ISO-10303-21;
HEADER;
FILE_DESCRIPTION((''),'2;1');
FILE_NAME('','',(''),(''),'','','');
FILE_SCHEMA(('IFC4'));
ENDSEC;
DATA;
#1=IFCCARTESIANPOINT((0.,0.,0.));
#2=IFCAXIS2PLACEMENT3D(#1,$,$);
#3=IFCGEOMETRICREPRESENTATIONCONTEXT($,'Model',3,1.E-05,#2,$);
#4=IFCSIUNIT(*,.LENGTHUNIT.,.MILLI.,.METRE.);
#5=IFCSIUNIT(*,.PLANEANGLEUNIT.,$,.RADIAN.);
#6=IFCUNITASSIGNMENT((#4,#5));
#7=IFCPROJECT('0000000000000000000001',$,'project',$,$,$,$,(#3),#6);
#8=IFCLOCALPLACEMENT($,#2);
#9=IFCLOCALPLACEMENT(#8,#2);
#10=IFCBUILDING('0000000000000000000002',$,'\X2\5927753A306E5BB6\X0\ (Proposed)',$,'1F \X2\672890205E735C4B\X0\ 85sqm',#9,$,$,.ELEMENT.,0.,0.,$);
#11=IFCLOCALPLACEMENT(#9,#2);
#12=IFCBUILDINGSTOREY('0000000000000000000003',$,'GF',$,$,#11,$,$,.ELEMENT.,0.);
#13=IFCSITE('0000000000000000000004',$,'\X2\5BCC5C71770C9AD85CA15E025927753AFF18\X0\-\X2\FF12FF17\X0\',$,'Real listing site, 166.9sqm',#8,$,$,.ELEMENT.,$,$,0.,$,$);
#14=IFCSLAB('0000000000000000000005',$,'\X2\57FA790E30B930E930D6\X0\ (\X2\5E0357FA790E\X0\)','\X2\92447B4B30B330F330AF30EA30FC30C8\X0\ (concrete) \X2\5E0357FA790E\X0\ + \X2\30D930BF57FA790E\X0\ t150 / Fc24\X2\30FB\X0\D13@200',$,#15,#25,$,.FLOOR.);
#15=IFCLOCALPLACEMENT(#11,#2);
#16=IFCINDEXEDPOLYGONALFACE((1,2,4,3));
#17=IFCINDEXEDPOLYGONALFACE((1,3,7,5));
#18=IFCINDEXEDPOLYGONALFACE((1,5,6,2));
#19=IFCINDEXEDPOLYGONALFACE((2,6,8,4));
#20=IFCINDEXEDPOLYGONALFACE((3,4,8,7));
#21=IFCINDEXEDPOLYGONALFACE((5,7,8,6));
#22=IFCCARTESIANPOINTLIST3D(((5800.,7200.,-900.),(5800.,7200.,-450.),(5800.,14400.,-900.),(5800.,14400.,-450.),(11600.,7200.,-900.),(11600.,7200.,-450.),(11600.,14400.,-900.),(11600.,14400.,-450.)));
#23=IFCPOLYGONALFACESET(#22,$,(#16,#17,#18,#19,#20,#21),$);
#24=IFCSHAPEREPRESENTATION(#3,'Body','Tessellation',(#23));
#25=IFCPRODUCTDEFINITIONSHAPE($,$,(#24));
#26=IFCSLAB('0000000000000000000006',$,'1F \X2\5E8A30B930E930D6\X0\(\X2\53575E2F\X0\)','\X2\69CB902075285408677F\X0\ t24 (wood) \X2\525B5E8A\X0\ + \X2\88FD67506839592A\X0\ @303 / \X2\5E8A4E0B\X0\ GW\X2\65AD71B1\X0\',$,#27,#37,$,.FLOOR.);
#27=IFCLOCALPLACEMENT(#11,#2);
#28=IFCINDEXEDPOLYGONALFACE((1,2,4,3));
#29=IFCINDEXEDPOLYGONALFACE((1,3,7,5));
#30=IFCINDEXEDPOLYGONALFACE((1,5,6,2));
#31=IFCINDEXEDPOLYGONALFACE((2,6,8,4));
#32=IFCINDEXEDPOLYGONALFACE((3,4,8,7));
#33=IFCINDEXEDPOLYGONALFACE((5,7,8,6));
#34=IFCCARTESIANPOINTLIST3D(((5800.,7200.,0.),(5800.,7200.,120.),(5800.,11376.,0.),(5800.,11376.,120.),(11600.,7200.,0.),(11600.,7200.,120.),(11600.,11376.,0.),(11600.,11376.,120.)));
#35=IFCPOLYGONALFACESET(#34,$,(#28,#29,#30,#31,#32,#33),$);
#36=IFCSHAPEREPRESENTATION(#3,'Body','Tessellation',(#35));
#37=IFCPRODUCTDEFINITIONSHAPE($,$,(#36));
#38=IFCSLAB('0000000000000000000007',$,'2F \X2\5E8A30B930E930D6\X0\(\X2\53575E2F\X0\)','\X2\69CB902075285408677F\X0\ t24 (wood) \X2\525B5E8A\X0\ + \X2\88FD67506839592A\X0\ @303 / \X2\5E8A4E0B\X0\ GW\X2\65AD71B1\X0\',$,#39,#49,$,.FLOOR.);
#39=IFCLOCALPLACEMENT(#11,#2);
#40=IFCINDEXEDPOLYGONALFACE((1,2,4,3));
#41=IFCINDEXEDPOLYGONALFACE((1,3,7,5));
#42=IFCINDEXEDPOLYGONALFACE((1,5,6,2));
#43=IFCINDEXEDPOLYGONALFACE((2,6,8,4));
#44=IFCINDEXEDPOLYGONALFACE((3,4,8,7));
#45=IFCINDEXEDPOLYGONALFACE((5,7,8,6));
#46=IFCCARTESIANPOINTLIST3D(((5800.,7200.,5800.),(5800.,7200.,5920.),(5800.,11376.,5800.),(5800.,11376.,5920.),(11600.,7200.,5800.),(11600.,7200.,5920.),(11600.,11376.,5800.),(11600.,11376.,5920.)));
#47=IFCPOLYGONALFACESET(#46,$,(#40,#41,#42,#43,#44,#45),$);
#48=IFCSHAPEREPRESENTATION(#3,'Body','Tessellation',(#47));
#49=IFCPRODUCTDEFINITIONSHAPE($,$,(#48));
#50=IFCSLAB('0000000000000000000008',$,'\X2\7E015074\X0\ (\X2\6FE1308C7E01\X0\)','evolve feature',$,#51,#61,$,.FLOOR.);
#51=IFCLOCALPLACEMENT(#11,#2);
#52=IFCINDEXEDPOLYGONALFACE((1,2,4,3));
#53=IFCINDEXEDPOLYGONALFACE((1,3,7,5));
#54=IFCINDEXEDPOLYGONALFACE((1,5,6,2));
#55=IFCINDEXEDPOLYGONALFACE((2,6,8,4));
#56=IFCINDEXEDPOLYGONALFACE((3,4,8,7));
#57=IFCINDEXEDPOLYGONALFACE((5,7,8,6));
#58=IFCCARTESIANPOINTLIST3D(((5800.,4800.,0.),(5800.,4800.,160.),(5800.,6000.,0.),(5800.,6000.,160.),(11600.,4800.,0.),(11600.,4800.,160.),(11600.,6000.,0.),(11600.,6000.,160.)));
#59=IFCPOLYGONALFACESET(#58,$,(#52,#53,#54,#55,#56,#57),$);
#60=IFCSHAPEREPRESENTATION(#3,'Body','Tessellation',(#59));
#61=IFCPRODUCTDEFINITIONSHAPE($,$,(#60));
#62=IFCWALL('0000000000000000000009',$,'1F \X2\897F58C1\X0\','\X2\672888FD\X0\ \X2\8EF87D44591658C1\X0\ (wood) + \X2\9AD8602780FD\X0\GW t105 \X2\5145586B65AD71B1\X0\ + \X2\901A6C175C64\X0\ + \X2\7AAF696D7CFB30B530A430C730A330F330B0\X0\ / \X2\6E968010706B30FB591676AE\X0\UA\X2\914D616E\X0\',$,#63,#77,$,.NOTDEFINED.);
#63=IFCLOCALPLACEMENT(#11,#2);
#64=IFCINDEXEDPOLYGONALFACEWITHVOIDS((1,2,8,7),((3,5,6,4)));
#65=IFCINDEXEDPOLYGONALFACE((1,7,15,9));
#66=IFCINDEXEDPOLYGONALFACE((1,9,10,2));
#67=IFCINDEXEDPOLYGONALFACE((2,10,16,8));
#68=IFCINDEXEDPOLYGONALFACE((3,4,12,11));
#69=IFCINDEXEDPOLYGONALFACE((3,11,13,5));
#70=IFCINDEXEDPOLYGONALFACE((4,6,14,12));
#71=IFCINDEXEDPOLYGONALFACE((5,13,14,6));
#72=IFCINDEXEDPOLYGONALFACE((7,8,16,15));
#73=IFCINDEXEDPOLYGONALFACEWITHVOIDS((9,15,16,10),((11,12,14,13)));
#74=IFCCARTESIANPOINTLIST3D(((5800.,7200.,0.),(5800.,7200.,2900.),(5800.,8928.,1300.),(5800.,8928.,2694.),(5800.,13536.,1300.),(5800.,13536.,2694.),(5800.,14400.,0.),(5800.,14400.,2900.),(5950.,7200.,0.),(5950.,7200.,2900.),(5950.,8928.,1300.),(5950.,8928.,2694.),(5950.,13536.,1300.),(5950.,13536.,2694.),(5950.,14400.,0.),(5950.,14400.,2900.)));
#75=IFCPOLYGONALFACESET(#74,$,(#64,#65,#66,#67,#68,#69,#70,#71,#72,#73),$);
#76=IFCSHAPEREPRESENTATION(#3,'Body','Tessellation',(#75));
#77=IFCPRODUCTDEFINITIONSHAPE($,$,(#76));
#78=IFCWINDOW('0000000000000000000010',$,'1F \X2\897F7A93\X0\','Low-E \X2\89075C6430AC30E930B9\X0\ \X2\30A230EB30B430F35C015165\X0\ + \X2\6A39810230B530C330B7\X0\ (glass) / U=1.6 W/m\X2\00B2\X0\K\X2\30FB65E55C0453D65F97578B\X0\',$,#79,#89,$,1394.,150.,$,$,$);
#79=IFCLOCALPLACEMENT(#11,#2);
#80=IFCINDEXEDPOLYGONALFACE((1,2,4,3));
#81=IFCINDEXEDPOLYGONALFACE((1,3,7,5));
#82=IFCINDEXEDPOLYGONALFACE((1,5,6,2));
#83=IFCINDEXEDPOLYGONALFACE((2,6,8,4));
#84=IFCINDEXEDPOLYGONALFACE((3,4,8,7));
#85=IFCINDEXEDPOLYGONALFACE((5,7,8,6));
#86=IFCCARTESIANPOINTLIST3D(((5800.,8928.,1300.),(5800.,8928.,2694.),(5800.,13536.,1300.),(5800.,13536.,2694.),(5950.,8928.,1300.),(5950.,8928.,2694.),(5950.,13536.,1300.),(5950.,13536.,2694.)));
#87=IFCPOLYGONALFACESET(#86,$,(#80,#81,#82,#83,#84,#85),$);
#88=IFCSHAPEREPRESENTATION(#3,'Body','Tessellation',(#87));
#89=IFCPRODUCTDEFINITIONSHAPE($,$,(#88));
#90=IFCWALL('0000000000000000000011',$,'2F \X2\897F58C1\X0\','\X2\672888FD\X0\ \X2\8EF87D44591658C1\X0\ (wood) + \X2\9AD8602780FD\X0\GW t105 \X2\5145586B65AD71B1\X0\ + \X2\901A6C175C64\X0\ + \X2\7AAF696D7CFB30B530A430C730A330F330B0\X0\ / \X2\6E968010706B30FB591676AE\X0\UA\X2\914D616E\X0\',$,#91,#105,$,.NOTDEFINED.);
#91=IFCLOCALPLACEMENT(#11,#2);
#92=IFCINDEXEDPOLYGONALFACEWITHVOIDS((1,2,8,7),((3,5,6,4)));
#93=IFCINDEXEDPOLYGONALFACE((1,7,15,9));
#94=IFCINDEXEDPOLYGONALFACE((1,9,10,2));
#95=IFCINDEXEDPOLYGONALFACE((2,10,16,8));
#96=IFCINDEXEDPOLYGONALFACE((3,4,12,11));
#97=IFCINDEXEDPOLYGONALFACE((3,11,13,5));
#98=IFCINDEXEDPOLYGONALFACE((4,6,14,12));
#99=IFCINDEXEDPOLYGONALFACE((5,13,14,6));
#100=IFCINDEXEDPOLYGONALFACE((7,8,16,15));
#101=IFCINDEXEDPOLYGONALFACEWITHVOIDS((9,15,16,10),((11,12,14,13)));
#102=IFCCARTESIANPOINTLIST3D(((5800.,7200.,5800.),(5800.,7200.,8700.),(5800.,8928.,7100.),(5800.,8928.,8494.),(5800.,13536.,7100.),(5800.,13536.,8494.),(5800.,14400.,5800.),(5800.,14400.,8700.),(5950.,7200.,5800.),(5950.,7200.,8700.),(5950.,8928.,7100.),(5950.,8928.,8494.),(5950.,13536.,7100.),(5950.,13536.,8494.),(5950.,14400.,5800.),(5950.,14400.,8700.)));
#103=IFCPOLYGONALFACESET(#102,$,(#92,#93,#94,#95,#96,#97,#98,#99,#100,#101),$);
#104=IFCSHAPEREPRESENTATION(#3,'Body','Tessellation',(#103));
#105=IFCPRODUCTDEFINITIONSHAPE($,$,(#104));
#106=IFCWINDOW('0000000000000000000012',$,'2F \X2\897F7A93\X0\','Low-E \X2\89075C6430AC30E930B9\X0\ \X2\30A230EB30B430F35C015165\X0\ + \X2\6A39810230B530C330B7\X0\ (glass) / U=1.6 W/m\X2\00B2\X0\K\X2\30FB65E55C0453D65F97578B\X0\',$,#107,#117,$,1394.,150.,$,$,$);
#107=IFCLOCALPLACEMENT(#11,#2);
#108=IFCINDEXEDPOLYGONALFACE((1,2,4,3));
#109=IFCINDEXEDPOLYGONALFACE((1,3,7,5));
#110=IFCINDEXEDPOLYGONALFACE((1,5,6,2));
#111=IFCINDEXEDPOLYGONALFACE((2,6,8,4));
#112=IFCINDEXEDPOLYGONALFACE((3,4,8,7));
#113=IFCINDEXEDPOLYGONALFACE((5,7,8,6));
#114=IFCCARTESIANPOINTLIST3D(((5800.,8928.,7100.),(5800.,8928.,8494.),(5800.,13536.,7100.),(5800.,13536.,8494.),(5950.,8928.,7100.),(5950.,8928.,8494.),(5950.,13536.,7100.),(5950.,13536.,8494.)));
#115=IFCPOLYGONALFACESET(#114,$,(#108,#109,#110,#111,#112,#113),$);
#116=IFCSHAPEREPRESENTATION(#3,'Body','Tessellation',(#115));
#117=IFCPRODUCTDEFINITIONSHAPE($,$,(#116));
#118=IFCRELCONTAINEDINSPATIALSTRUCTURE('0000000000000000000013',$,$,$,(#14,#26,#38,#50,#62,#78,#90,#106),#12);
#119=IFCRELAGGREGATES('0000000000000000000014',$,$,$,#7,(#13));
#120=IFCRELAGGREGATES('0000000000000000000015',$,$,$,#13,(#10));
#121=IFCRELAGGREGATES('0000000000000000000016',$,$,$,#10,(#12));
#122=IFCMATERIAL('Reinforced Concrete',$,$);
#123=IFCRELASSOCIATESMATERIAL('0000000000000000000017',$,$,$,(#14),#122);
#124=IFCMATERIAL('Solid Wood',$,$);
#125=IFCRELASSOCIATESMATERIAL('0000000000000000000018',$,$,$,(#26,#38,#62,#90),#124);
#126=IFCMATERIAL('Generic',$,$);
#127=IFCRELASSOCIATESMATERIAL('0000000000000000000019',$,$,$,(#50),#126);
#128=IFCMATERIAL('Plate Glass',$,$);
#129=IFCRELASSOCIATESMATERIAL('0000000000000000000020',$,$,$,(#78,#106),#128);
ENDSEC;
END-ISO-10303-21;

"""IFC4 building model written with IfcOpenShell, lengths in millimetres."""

from ifc_helpers import new_model, si_unit, frame, frame_2d, origin, place, context, project, spatial, rectangle, extrude, material, element, fill, save


model = new_model("IFC4")

# Units and contexts
model_context = context("Model", 3, precision=1e-05, world=origin())
ifc_project = project(units=[si_unit("LENGTHUNIT", "METRE", prefix="MILLI"), si_unit("PLANEANGLEUNIT", "RADIAN")], contexts=[model_context])

# Site, building, storey
site_placement = place(None, origin())
site = spatial("IfcSite", under=ifc_project, at=site_placement, Name="富山県高岡市大町８-２７", ObjectType="Real listing site, 166.9sqm", CompositionType="ELEMENT", RefElevation=0.0)
building_placement = place(site_placement, origin())
building = spatial("IfcBuilding", under=site, at=building_placement, Name="大町の家 (Proposed)", ObjectType="1F 木造平屋 85sqm", CompositionType="ELEMENT", ElevationOfRefHeight=0.0, ElevationOfTerrain=0.0)
storey_placement = place(building_placement, origin())
storey = spatial("IfcBuildingStorey", under=building, at=storey_placement, Name="GF", CompositionType="ELEMENT", Elevation=0.0)

# Slabs
ifc_material_1 = material(Name="Reinforced Concrete")
slab_1_placement = place(storey_placement, frame((2900.0, 3600.0, -450.0)))
element("IfcSlab", 1, at=slab_1_placement, inside=storey, material=ifc_material_1, Name="基礎スラブ (布基礎)", Description="鉄筋コンクリート (concrete) 布基礎 + ベタ基礎 t150 / Fc24・D13@200", PredefinedType="FLOOR", context=model_context, shape_type="SweptSolid", body=[
    extrude(rectangle(XDim=5800.0, YDim=7200.0, at=frame_2d((2900.0, 3600.0))), frame((2900.0, 3600.0, -450.0)), (0.0, 0.0, 1.0), 450.0),
])
ifc_material_2 = material(Name="Solid Wood")
slab_2_placement = place(storey_placement, frame((2900.0, 3600.0, 0.0)))
element("IfcSlab", 2, at=slab_2_placement, inside=storey, material=ifc_material_2, Name="1F 床スラブ(南帯)", Description="構造用合板 t24 (wood) 剛床 + 製材根太 @303 / 床下 GW断熱", PredefinedType="FLOOR", context=model_context, shape_type="SweptSolid", body=[
    extrude(rectangle(XDim=5800.0, YDim=4176.0, at=frame_2d((2900.0, 2088.0))), frame((2900.0, 3600.0, 0.0)), (0.0, 0.0, 1.0), 120.0),
])
slab_3_placement = place(storey_placement, frame((2900.0, 3600.0, 2900.0)))
element("IfcSlab", 3, at=slab_3_placement, inside=storey, material=ifc_material_2, Name="2F 床スラブ(南帯)", Description="構造用合板 t24 (wood) 剛床 + 製材根太 @303 / 床下 GW断熱", PredefinedType="FLOOR", context=model_context, shape_type="SweptSolid", body=[
    extrude(rectangle(XDim=5800.0, YDim=4176.0, at=frame_2d((2900.0, 2088.0))), frame((2900.0, 3600.0, 2900.0)), (0.0, 0.0, 1.0), 120.0),
])
ifc_material_3 = material(Name="Generic")
slab_4_placement = place(storey_placement, frame((2900.0, 2400.0, 0.0)))
element("IfcSlab", 4, at=slab_4_placement, inside=storey, material=ifc_material_3, Name="縁側 (濡れ縁)", Description="evolve feature", PredefinedType="FLOOR", context=model_context, shape_type="SweptSolid", body=[
    extrude(rectangle(XDim=5800.0, YDim=1200.0, at=frame_2d((2900.0, 600.0))), frame((2900.0, 2400.0, 0.0)), (0.0, 0.0, 1.0), 160.0),
])

# Shared definitions
ifc_material_4 = material(Name="Plate Glass")

# Wall, opening, window
wall_1_placement = place(storey_placement, frame((2900.0, 3600.0, 0.0)))
wall_1 = element("IfcWall", 5, at=wall_1_placement, inside=storey, material=ifc_material_2, Name="1F 西壁", Description="木製 軸組外壁 (wood) + 高性能GW t105 充填断熱 + 通気層 + 窯業系サイディング / 準耐火・外皮UA配慮", PredefinedType="NOTDEFINED", context=model_context, shape_type="SweptSolid", body=[
    extrude(rectangle(XDim=150.0, YDim=7200.0, at=frame_2d((75.0, 3600.0))), frame((2900.0, 3600.0, 0.0)), (0.0, 0.0, 1.0), 2900.0),
])
opening_1_placement = place(storey_placement, frame((2900.0, 4464.0, 650.0)))
opening_1 = element("IfcOpeningElement", 6, at=opening_1_placement, cuts=wall_1, PredefinedType="NOTDEFINED", context=model_context, shape_type="SweptSolid", body=[
    extrude(rectangle(XDim=150.0, YDim=4608.0, at=frame_2d((75.0, 2304.0))), frame((2900.0, 4464.0, 650.0)), (0.0, 0.0, 1.0), 1394.0),
])
window_1_placement = place(storey_placement, frame((2900.0, 4464.0, 650.0)))
window_1 = element("IfcWindow", 7, at=window_1_placement, inside=storey, material=ifc_material_4, Name="1F 西窓", Description="Low-E 複層ガラス アルゴン封入 + 樹脂サッシ (glass) / U=1.6 W/m²K・日射取得型", OverallHeight=1394.0, OverallWidth=150.0, context=model_context, shape_type="SweptSolid", body=[
    extrude(rectangle(XDim=150.0, YDim=4608.0, at=frame_2d((75.0, 2304.0))), frame((2900.0, 4464.0, 650.0)), (0.0, 0.0, 1.0), 1394.0),
])
fill(opening_1, window_1)

# Wall, opening, window
wall_2_placement = place(storey_placement, frame((2900.0, 3600.0, 2900.0)))
wall_2 = element("IfcWall", 8, at=wall_2_placement, inside=storey, material=ifc_material_2, Name="2F 西壁", Description="木製 軸組外壁 (wood) + 高性能GW t105 充填断熱 + 通気層 + 窯業系サイディング / 準耐火・外皮UA配慮", PredefinedType="NOTDEFINED", context=model_context, shape_type="SweptSolid", body=[
    extrude(rectangle(XDim=150.0, YDim=7200.0, at=frame_2d((75.0, 3600.0))), frame((2900.0, 3600.0, 2900.0)), (0.0, 0.0, 1.0), 2900.0),
])
opening_2_placement = place(storey_placement, frame((2900.0, 4464.0, 3550.0)))
opening_2 = element("IfcOpeningElement", 9, at=opening_2_placement, cuts=wall_2, PredefinedType="NOTDEFINED", context=model_context, shape_type="SweptSolid", body=[
    extrude(rectangle(XDim=150.0, YDim=4608.0, at=frame_2d((75.0, 2304.0))), frame((2900.0, 4464.0, 3550.0)), (0.0, 0.0, 1.0), 1394.0),
])
window_2_placement = place(storey_placement, frame((2900.0, 4464.0, 3550.0)))
window_2 = element("IfcWindow", 10, at=window_2_placement, inside=storey, material=ifc_material_4, Name="2F 西窓", Description="Low-E 複層ガラス アルゴン封入 + 樹脂サッシ (glass) / U=1.6 W/m²K・日射取得型", OverallHeight=1394.0, OverallWidth=150.0, context=model_context, shape_type="SweptSolid", body=[
    extrude(rectangle(XDim=150.0, YDim=4608.0, at=frame_2d((75.0, 2304.0))), frame((2900.0, 4464.0, 3550.0)), (0.0, 0.0, 1.0), 1394.0),
])
fill(opening_2, window_2)

save(model, "model.ifc")
